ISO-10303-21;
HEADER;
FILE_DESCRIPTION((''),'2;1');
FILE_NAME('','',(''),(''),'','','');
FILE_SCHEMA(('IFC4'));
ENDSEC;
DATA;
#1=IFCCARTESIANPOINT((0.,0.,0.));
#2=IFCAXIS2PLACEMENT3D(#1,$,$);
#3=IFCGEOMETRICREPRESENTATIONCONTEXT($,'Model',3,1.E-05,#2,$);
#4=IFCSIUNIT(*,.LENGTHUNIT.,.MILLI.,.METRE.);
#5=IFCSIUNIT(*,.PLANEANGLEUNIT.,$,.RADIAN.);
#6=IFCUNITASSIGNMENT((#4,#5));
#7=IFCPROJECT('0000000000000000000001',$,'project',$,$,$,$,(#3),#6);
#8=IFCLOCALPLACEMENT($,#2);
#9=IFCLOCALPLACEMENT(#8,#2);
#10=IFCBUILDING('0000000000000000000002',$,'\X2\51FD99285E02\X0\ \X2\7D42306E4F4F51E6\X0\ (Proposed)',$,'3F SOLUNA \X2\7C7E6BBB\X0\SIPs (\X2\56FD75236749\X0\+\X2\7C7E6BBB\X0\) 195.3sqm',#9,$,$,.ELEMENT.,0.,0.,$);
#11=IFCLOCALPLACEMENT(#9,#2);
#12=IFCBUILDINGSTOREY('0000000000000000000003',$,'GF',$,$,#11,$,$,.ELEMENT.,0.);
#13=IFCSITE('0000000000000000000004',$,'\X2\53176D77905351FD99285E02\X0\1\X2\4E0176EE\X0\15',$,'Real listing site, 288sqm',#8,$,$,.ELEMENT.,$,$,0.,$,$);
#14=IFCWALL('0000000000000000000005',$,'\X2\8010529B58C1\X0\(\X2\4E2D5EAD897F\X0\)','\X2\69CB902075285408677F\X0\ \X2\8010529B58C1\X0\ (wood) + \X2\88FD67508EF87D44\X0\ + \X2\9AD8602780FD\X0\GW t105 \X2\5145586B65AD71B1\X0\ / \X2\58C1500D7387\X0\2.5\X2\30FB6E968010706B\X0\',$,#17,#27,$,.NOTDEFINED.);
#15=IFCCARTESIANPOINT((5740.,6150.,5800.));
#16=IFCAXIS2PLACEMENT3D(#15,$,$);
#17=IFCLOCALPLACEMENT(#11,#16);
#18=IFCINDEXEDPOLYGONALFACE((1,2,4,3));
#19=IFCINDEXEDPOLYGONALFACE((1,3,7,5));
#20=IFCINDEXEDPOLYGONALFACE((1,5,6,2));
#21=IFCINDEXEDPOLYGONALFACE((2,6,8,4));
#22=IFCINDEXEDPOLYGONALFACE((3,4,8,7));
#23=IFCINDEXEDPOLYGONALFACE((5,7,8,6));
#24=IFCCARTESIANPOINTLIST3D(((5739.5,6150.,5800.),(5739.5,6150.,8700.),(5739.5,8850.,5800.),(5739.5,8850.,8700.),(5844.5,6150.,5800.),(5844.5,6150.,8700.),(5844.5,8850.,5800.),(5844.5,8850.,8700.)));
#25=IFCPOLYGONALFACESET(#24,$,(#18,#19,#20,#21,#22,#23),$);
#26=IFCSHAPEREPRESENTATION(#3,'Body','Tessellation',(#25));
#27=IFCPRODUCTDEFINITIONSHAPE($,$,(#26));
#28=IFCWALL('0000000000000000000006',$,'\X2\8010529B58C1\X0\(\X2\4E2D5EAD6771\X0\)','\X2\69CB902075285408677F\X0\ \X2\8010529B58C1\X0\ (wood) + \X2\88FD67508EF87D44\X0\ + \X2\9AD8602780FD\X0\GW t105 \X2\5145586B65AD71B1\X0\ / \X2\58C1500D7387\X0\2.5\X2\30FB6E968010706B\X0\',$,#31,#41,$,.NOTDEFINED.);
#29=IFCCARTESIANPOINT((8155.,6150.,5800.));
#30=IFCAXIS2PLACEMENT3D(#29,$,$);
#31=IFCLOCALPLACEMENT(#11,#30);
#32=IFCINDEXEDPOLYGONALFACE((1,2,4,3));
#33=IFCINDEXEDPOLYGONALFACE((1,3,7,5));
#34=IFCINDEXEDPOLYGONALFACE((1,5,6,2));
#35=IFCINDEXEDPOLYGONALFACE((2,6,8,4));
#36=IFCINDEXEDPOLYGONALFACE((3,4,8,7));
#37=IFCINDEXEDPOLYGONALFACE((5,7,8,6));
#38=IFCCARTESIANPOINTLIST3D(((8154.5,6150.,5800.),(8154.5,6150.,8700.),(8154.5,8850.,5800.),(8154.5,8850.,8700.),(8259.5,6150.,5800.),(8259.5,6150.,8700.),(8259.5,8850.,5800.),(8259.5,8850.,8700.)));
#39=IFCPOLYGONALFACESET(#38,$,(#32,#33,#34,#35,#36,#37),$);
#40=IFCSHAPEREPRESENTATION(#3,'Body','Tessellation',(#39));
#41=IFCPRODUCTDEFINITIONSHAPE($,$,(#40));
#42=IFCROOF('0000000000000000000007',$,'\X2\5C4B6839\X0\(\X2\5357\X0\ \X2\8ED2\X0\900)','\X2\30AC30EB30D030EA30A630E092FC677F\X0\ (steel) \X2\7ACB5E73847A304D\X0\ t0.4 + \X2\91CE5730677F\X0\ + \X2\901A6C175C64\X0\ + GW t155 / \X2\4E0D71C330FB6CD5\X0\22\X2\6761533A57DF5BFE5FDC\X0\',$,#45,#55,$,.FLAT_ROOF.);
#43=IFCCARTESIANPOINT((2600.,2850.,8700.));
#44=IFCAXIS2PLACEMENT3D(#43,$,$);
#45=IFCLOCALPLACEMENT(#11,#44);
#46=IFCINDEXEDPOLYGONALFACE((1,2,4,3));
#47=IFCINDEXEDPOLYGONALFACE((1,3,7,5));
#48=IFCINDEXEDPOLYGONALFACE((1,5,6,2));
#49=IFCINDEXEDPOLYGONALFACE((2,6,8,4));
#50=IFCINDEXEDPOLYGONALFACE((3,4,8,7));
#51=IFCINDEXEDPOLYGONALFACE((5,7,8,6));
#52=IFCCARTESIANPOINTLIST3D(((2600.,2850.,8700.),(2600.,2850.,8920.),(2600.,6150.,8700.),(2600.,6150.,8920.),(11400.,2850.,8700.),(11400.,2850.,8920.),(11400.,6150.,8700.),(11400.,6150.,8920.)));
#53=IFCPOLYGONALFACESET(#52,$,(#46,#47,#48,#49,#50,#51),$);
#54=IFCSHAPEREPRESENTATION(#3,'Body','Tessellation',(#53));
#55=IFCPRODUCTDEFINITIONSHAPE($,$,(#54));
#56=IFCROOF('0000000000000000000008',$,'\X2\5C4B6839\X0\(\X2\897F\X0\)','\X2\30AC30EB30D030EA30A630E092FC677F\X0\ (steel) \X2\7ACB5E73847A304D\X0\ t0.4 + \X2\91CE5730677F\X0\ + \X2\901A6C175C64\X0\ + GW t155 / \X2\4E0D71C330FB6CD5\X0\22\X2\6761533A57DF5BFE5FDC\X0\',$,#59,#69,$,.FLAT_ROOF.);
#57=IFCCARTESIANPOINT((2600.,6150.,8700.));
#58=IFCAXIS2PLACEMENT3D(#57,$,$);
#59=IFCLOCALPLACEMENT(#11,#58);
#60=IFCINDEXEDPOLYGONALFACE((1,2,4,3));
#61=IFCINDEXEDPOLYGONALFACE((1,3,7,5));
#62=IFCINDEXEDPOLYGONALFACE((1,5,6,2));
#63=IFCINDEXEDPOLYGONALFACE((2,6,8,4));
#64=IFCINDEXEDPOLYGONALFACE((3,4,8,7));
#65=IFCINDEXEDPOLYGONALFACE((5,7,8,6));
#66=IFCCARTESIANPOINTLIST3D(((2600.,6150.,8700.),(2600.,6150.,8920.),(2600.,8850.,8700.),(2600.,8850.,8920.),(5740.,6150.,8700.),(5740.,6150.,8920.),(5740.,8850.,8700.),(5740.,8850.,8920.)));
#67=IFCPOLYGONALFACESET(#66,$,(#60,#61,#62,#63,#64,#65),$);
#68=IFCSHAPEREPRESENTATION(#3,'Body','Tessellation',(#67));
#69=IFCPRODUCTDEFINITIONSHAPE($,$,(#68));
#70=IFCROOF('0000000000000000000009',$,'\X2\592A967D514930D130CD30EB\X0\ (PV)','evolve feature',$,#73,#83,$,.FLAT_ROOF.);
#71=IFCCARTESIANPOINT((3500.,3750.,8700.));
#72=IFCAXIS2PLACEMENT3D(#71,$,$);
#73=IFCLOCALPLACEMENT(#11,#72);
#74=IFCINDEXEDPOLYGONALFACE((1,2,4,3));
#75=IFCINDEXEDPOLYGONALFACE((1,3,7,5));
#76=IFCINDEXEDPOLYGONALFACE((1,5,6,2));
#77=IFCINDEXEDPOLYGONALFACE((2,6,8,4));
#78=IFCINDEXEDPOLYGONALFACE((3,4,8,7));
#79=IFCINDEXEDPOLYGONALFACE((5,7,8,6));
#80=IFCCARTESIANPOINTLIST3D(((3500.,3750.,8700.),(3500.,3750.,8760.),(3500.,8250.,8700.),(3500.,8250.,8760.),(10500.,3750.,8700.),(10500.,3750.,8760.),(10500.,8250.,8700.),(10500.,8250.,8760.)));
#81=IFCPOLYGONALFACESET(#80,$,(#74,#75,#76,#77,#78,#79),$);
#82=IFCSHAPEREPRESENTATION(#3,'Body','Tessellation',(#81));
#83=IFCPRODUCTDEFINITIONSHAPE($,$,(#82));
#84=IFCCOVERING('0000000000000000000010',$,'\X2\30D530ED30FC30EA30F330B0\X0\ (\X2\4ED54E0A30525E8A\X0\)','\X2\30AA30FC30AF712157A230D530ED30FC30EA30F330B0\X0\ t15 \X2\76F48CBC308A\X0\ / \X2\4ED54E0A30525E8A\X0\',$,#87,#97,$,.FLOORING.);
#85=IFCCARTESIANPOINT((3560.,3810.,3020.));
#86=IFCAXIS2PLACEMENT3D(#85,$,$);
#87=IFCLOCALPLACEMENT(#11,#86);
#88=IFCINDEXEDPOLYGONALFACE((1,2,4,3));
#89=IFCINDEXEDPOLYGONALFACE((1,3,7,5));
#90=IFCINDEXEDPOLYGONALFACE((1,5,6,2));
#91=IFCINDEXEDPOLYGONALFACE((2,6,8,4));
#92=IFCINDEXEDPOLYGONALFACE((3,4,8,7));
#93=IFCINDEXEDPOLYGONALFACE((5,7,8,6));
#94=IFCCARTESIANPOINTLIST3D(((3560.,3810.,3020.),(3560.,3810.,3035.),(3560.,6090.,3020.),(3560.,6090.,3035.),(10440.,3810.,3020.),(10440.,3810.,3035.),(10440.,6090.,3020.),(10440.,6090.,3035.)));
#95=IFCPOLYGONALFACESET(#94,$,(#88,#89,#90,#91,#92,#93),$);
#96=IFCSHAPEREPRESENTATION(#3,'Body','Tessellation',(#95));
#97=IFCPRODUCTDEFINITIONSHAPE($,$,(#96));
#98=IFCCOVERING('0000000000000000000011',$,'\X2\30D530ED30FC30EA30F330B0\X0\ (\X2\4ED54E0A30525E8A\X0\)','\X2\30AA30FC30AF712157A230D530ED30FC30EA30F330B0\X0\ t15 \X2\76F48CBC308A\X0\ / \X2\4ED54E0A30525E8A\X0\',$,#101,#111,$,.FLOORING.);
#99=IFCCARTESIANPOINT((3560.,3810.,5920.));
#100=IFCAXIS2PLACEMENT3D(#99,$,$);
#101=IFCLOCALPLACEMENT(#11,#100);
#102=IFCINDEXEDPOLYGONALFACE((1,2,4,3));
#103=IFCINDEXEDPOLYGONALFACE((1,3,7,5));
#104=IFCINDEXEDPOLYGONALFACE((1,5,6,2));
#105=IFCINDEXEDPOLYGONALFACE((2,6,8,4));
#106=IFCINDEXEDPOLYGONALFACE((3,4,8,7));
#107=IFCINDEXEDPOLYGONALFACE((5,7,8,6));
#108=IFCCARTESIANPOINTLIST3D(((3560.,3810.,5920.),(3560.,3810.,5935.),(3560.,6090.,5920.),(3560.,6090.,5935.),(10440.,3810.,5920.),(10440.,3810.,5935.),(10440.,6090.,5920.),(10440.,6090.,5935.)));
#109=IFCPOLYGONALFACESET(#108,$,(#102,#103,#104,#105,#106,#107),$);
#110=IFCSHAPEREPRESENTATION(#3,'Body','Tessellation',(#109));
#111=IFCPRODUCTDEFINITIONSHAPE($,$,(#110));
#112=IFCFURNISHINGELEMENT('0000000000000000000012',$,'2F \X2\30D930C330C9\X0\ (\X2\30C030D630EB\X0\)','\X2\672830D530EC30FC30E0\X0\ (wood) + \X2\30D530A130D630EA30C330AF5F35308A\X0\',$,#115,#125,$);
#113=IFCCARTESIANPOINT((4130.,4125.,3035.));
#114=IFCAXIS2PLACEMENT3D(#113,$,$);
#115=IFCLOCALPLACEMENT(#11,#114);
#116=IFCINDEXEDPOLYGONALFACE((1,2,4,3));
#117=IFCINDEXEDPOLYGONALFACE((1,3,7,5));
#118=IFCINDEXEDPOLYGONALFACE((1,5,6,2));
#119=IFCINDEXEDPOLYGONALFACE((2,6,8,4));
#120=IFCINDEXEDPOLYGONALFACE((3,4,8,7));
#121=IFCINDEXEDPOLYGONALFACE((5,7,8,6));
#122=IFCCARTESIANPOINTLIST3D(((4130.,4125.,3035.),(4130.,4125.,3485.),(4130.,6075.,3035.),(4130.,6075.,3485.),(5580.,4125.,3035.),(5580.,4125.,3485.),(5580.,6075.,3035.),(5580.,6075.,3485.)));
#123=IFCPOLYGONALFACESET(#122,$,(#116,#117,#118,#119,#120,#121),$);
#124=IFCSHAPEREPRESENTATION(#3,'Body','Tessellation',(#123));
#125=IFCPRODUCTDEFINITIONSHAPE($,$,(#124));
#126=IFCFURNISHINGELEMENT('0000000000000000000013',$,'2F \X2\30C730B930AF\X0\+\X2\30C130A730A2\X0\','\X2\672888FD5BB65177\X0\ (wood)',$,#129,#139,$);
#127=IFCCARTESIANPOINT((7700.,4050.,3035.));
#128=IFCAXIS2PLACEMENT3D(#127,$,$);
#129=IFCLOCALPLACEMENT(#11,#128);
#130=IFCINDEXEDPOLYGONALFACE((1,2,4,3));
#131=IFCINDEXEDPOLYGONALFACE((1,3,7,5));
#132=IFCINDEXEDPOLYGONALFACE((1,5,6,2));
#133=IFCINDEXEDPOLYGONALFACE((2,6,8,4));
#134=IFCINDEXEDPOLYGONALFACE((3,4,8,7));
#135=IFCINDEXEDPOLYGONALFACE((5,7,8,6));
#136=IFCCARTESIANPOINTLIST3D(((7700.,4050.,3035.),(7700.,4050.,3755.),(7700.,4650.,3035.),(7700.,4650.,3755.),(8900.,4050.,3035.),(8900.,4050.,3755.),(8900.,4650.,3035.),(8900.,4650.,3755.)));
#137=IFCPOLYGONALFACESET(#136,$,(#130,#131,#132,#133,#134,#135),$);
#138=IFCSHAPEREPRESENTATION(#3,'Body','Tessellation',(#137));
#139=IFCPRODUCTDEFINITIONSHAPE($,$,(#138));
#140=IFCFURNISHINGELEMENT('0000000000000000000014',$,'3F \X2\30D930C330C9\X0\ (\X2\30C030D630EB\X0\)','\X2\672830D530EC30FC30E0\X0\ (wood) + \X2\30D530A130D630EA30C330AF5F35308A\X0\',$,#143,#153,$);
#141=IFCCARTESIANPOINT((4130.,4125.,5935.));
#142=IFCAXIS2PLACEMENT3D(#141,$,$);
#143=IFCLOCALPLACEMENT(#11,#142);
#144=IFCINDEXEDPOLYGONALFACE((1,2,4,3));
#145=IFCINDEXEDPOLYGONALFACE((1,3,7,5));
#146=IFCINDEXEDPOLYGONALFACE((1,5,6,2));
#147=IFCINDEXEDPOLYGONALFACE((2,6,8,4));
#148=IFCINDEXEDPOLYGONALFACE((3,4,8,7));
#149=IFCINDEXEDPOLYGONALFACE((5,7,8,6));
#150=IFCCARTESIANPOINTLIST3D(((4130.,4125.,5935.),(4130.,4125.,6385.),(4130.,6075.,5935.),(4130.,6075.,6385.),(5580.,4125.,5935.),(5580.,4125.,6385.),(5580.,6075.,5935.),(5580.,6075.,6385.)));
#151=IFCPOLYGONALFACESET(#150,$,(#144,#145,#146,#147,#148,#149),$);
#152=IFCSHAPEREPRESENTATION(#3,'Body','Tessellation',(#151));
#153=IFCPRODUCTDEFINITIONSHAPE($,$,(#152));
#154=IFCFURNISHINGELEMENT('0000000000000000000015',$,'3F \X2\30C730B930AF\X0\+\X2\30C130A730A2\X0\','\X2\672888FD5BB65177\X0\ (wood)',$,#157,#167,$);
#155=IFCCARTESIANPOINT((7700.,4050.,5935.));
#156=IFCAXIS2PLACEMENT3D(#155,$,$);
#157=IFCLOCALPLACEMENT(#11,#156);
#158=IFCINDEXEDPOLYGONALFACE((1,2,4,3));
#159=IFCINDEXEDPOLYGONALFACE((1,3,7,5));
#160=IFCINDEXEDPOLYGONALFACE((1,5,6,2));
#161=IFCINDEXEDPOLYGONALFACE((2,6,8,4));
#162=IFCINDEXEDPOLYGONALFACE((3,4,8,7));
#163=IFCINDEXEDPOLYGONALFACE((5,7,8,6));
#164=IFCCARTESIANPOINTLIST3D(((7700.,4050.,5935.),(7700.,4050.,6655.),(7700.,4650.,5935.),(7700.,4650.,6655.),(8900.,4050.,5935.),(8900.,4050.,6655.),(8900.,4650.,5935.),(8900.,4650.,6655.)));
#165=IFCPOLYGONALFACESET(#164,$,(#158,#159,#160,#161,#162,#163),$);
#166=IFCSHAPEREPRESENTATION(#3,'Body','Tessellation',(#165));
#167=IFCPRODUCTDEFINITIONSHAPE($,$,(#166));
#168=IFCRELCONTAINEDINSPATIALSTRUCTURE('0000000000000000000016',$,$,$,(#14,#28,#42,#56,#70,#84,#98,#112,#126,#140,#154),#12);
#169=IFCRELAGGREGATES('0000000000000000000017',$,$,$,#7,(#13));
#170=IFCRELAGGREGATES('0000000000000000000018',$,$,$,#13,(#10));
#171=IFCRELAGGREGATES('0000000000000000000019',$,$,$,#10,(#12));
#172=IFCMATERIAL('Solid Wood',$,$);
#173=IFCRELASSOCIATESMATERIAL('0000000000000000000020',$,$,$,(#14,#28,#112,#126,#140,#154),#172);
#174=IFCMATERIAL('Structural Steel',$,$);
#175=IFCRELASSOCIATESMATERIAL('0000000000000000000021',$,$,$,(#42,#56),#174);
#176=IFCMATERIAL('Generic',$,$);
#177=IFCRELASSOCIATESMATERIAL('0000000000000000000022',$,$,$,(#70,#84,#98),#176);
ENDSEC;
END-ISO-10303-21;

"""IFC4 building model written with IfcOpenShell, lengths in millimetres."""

from ifc_helpers import new_model, si_unit, frame, frame_2d, origin, place, context, project, spatial, rectangle, extrude, material, element, save


model = new_model("IFC4")

# Units and contexts
model_context = context("Model", 3, precision=1e-05, world=origin())
ifc_project = project(units=[si_unit("LENGTHUNIT", "METRE", prefix="MILLI"), si_unit("PLANEANGLEUNIT", "RADIAN")], contexts=[model_context])

# Site, building, storey
site_placement = place(None, origin())
site = spatial("IfcSite", under=ifc_project, at=site_placement, Name="北海道函館市1丁目15", ObjectType="Real listing site, 288sqm", CompositionType="ELEMENT", RefElevation=0.0)
building_placement = place(site_placement, origin())
building = spatial("IfcBuilding", under=site, at=building_placement, Name="函館市 終の住処 (Proposed)", ObjectType="3F SOLUNA 籾殻SIPs (国産杉+籾殻) 195.3sqm", CompositionType="ELEMENT", ElevationOfRefHeight=0.0, ElevationOfTerrain=0.0)
storey_placement = place(building_placement, origin())
storey = spatial("IfcBuildingStorey", under=building, at=storey_placement, Name="GF", CompositionType="ELEMENT", Elevation=0.0)

# Shared definitions
ifc_material_1 = material(Name="Solid Wood")

# Walls
wall_1_placement = place(storey_placement, frame((5740.0, 6150.0, 5800.0)))
element("IfcWall", 1, at=wall_1_placement, inside=storey, material=ifc_material_1, Name="耐力壁(中庭西)", Description="構造用合板 耐力壁 (wood) + 製材軸組 + 高性能GW t105 充填断熱 / 壁倍率2.5・準耐火", PredefinedType="NOTDEFINED", context=model_context, shape_type="SweptSolid", body=[
    extrude(rectangle(XDim=105.0, YDim=2700.0, at=frame_2d((52.0, 1350.0))), frame((5740.0, 6150.0, 5800.0)), (0.0, 0.0, 1.0), 2900.0),
])
wall_2_placement = place(storey_placement, frame((8155.0, 6150.0, 5800.0)))
element("IfcWall", 2, at=wall_2_placement, inside=storey, material=ifc_material_1, Name="耐力壁(中庭東)", Description="構造用合板 耐力壁 (wood) + 製材軸組 + 高性能GW t105 充填断熱 / 壁倍率2.5・準耐火", PredefinedType="NOTDEFINED", context=model_context, shape_type="SweptSolid", body=[
    extrude(rectangle(XDim=105.0, YDim=2700.0, at=frame_2d((52.0, 1350.0))), frame((8155.0, 6150.0, 5800.0)), (0.0, 0.0, 1.0), 2900.0),
])

# Roofs
ifc_material_2 = material(Name="Structural Steel")
roof_1_placement = place(storey_placement, frame((2600.0, 2850.0, 8700.0)))
element("IfcRoof", 3, at=roof_1_placement, inside=storey, material=ifc_material_2, Name="屋根(南 軒900)", Description="ガルバリウム鋼板 (steel) 立平葺き t0.4 + 野地板 + 通気層 + GW t155 / 不燃・法22条区域対応", PredefinedType="FLAT_ROOF", context=model_context, shape_type="SweptSolid", body=[
    extrude(rectangle(XDim=8800.0, YDim=3300.0, at=frame_2d((4400.0, 1650.0))), frame((2600.0, 2850.0, 8700.0)), (0.0, 0.0, 1.0), 220.0),
])
roof_2_placement = place(storey_placement, frame((2600.0, 6150.0, 8700.0)))
element("IfcRoof", 4, at=roof_2_placement, inside=storey, material=ifc_material_2, Name="屋根(西)", Description="ガルバリウム鋼板 (steel) 立平葺き t0.4 + 野地板 + 通気層 + GW t155 / 不燃・法22条区域対応", PredefinedType="FLAT_ROOF", context=model_context, shape_type="SweptSolid", body=[
    extrude(rectangle(XDim=3140.0, YDim=2700.0, at=frame_2d((1570.0, 1350.0))), frame((2600.0, 6150.0, 8700.0)), (0.0, 0.0, 1.0), 220.0),
])
ifc_material_3 = material(Name="Generic")
roof_3_placement = place(storey_placement, frame((3500.0, 3750.0, 8700.0)))
element("IfcRoof", 5, at=roof_3_placement, inside=storey, material=ifc_material_3, Name="太陽光パネル (PV)", Description="evolve feature", PredefinedType="FLAT_ROOF", context=model_context, shape_type="SweptSolid", body=[
    extrude(rectangle(XDim=7000.0, YDim=4500.0, at=frame_2d((3500.0, 2250.0))), frame((3500.0, 3750.0, 8700.0)), (0.0, 0.0, 1.0), 60.0),
])

# Coverings
covering_1_placement = place(storey_placement, frame((3560.0, 3810.0, 3020.0)))
element("IfcCovering", 6, at=covering_1_placement, inside=storey, material=ifc_material_3, Name="フローリング (仕上げ床)", Description="オーク無垢フローリング t15 直貼り / 仕上げ床", PredefinedType="FLOORING", context=model_context, shape_type="SweptSolid", body=[
    extrude(rectangle(XDim=6880.0, YDim=2280.0, at=frame_2d((3440.0, 1140.0))), frame((3560.0, 3810.0, 3020.0)), (0.0, 0.0, 1.0), 15.0),
])
covering_2_placement = place(storey_placement, frame((3560.0, 3810.0, 5920.0)))
element("IfcCovering", 7, at=covering_2_placement, inside=storey, material=ifc_material_3, Name="フローリング (仕上げ床)", Description="オーク無垢フローリング t15 直貼り / 仕上げ床", PredefinedType="FLOORING", context=model_context, shape_type="SweptSolid", body=[
    extrude(rectangle(XDim=6880.0, YDim=2280.0, at=frame_2d((3440.0, 1140.0))), frame((3560.0, 3810.0, 5920.0)), (0.0, 0.0, 1.0), 15.0),
])

# Furnishing elements
furnishing_1_placement = place(storey_placement, frame((4130.0, 4125.0, 3035.0)))
element("IfcFurnishingElement", 8, at=furnishing_1_placement, inside=storey, material=ifc_material_1, Name="2F ベッド (ダブル)", Description="木フレーム (wood) + ファブリック張り", context=model_context, shape_type="SweptSolid", body=[
    extrude(rectangle(XDim=1450.0, YDim=1950.0, at=frame_2d((725.0, 975.0))), frame((4130.0, 4125.0, 3035.0)), (0.0, 0.0, 1.0), 450.0),
])
furnishing_2_placement = place(storey_placement, frame((7700.0, 4050.0, 3035.0)))
element("IfcFurnishingElement", 9, at=furnishing_2_placement, inside=storey, material=ifc_material_1, Name="2F デスク+チェア", Description="木製家具 (wood)", context=model_context, shape_type="SweptSolid", body=[
    extrude(rectangle(XDim=1200.0, YDim=600.0, at=frame_2d((600.0, 300.0))), frame((7700.0, 4050.0, 3035.0)), (0.0, 0.0, 1.0), 720.0),
])
furnishing_3_placement = place(storey_placement, frame((4130.0, 4125.0, 5935.0)))
element("IfcFurnishingElement", 10, at=furnishing_3_placement, inside=storey, material=ifc_material_1, Name="3F ベッド (ダブル)", Description="木フレーム (wood) + ファブリック張り", context=model_context, shape_type="SweptSolid", body=[
    extrude(rectangle(XDim=1450.0, YDim=1950.0, at=frame_2d((725.0, 975.0))), frame((4130.0, 4125.0, 5935.0)), (0.0, 0.0, 1.0), 450.0),
])
furnishing_4_placement = place(storey_placement, frame((7700.0, 4050.0, 5935.0)))
element("IfcFurnishingElement", 11, at=furnishing_4_placement, inside=storey, material=ifc_material_1, Name="3F デスク+チェア", Description="木製家具 (wood)", context=model_context, shape_type="SweptSolid", body=[
    extrude(rectangle(XDim=1200.0, YDim=600.0, at=frame_2d((600.0, 300.0))), frame((7700.0, 4050.0, 5935.0)), (0.0, 0.0, 1.0), 720.0),
])

save(model, "model.ifc")
